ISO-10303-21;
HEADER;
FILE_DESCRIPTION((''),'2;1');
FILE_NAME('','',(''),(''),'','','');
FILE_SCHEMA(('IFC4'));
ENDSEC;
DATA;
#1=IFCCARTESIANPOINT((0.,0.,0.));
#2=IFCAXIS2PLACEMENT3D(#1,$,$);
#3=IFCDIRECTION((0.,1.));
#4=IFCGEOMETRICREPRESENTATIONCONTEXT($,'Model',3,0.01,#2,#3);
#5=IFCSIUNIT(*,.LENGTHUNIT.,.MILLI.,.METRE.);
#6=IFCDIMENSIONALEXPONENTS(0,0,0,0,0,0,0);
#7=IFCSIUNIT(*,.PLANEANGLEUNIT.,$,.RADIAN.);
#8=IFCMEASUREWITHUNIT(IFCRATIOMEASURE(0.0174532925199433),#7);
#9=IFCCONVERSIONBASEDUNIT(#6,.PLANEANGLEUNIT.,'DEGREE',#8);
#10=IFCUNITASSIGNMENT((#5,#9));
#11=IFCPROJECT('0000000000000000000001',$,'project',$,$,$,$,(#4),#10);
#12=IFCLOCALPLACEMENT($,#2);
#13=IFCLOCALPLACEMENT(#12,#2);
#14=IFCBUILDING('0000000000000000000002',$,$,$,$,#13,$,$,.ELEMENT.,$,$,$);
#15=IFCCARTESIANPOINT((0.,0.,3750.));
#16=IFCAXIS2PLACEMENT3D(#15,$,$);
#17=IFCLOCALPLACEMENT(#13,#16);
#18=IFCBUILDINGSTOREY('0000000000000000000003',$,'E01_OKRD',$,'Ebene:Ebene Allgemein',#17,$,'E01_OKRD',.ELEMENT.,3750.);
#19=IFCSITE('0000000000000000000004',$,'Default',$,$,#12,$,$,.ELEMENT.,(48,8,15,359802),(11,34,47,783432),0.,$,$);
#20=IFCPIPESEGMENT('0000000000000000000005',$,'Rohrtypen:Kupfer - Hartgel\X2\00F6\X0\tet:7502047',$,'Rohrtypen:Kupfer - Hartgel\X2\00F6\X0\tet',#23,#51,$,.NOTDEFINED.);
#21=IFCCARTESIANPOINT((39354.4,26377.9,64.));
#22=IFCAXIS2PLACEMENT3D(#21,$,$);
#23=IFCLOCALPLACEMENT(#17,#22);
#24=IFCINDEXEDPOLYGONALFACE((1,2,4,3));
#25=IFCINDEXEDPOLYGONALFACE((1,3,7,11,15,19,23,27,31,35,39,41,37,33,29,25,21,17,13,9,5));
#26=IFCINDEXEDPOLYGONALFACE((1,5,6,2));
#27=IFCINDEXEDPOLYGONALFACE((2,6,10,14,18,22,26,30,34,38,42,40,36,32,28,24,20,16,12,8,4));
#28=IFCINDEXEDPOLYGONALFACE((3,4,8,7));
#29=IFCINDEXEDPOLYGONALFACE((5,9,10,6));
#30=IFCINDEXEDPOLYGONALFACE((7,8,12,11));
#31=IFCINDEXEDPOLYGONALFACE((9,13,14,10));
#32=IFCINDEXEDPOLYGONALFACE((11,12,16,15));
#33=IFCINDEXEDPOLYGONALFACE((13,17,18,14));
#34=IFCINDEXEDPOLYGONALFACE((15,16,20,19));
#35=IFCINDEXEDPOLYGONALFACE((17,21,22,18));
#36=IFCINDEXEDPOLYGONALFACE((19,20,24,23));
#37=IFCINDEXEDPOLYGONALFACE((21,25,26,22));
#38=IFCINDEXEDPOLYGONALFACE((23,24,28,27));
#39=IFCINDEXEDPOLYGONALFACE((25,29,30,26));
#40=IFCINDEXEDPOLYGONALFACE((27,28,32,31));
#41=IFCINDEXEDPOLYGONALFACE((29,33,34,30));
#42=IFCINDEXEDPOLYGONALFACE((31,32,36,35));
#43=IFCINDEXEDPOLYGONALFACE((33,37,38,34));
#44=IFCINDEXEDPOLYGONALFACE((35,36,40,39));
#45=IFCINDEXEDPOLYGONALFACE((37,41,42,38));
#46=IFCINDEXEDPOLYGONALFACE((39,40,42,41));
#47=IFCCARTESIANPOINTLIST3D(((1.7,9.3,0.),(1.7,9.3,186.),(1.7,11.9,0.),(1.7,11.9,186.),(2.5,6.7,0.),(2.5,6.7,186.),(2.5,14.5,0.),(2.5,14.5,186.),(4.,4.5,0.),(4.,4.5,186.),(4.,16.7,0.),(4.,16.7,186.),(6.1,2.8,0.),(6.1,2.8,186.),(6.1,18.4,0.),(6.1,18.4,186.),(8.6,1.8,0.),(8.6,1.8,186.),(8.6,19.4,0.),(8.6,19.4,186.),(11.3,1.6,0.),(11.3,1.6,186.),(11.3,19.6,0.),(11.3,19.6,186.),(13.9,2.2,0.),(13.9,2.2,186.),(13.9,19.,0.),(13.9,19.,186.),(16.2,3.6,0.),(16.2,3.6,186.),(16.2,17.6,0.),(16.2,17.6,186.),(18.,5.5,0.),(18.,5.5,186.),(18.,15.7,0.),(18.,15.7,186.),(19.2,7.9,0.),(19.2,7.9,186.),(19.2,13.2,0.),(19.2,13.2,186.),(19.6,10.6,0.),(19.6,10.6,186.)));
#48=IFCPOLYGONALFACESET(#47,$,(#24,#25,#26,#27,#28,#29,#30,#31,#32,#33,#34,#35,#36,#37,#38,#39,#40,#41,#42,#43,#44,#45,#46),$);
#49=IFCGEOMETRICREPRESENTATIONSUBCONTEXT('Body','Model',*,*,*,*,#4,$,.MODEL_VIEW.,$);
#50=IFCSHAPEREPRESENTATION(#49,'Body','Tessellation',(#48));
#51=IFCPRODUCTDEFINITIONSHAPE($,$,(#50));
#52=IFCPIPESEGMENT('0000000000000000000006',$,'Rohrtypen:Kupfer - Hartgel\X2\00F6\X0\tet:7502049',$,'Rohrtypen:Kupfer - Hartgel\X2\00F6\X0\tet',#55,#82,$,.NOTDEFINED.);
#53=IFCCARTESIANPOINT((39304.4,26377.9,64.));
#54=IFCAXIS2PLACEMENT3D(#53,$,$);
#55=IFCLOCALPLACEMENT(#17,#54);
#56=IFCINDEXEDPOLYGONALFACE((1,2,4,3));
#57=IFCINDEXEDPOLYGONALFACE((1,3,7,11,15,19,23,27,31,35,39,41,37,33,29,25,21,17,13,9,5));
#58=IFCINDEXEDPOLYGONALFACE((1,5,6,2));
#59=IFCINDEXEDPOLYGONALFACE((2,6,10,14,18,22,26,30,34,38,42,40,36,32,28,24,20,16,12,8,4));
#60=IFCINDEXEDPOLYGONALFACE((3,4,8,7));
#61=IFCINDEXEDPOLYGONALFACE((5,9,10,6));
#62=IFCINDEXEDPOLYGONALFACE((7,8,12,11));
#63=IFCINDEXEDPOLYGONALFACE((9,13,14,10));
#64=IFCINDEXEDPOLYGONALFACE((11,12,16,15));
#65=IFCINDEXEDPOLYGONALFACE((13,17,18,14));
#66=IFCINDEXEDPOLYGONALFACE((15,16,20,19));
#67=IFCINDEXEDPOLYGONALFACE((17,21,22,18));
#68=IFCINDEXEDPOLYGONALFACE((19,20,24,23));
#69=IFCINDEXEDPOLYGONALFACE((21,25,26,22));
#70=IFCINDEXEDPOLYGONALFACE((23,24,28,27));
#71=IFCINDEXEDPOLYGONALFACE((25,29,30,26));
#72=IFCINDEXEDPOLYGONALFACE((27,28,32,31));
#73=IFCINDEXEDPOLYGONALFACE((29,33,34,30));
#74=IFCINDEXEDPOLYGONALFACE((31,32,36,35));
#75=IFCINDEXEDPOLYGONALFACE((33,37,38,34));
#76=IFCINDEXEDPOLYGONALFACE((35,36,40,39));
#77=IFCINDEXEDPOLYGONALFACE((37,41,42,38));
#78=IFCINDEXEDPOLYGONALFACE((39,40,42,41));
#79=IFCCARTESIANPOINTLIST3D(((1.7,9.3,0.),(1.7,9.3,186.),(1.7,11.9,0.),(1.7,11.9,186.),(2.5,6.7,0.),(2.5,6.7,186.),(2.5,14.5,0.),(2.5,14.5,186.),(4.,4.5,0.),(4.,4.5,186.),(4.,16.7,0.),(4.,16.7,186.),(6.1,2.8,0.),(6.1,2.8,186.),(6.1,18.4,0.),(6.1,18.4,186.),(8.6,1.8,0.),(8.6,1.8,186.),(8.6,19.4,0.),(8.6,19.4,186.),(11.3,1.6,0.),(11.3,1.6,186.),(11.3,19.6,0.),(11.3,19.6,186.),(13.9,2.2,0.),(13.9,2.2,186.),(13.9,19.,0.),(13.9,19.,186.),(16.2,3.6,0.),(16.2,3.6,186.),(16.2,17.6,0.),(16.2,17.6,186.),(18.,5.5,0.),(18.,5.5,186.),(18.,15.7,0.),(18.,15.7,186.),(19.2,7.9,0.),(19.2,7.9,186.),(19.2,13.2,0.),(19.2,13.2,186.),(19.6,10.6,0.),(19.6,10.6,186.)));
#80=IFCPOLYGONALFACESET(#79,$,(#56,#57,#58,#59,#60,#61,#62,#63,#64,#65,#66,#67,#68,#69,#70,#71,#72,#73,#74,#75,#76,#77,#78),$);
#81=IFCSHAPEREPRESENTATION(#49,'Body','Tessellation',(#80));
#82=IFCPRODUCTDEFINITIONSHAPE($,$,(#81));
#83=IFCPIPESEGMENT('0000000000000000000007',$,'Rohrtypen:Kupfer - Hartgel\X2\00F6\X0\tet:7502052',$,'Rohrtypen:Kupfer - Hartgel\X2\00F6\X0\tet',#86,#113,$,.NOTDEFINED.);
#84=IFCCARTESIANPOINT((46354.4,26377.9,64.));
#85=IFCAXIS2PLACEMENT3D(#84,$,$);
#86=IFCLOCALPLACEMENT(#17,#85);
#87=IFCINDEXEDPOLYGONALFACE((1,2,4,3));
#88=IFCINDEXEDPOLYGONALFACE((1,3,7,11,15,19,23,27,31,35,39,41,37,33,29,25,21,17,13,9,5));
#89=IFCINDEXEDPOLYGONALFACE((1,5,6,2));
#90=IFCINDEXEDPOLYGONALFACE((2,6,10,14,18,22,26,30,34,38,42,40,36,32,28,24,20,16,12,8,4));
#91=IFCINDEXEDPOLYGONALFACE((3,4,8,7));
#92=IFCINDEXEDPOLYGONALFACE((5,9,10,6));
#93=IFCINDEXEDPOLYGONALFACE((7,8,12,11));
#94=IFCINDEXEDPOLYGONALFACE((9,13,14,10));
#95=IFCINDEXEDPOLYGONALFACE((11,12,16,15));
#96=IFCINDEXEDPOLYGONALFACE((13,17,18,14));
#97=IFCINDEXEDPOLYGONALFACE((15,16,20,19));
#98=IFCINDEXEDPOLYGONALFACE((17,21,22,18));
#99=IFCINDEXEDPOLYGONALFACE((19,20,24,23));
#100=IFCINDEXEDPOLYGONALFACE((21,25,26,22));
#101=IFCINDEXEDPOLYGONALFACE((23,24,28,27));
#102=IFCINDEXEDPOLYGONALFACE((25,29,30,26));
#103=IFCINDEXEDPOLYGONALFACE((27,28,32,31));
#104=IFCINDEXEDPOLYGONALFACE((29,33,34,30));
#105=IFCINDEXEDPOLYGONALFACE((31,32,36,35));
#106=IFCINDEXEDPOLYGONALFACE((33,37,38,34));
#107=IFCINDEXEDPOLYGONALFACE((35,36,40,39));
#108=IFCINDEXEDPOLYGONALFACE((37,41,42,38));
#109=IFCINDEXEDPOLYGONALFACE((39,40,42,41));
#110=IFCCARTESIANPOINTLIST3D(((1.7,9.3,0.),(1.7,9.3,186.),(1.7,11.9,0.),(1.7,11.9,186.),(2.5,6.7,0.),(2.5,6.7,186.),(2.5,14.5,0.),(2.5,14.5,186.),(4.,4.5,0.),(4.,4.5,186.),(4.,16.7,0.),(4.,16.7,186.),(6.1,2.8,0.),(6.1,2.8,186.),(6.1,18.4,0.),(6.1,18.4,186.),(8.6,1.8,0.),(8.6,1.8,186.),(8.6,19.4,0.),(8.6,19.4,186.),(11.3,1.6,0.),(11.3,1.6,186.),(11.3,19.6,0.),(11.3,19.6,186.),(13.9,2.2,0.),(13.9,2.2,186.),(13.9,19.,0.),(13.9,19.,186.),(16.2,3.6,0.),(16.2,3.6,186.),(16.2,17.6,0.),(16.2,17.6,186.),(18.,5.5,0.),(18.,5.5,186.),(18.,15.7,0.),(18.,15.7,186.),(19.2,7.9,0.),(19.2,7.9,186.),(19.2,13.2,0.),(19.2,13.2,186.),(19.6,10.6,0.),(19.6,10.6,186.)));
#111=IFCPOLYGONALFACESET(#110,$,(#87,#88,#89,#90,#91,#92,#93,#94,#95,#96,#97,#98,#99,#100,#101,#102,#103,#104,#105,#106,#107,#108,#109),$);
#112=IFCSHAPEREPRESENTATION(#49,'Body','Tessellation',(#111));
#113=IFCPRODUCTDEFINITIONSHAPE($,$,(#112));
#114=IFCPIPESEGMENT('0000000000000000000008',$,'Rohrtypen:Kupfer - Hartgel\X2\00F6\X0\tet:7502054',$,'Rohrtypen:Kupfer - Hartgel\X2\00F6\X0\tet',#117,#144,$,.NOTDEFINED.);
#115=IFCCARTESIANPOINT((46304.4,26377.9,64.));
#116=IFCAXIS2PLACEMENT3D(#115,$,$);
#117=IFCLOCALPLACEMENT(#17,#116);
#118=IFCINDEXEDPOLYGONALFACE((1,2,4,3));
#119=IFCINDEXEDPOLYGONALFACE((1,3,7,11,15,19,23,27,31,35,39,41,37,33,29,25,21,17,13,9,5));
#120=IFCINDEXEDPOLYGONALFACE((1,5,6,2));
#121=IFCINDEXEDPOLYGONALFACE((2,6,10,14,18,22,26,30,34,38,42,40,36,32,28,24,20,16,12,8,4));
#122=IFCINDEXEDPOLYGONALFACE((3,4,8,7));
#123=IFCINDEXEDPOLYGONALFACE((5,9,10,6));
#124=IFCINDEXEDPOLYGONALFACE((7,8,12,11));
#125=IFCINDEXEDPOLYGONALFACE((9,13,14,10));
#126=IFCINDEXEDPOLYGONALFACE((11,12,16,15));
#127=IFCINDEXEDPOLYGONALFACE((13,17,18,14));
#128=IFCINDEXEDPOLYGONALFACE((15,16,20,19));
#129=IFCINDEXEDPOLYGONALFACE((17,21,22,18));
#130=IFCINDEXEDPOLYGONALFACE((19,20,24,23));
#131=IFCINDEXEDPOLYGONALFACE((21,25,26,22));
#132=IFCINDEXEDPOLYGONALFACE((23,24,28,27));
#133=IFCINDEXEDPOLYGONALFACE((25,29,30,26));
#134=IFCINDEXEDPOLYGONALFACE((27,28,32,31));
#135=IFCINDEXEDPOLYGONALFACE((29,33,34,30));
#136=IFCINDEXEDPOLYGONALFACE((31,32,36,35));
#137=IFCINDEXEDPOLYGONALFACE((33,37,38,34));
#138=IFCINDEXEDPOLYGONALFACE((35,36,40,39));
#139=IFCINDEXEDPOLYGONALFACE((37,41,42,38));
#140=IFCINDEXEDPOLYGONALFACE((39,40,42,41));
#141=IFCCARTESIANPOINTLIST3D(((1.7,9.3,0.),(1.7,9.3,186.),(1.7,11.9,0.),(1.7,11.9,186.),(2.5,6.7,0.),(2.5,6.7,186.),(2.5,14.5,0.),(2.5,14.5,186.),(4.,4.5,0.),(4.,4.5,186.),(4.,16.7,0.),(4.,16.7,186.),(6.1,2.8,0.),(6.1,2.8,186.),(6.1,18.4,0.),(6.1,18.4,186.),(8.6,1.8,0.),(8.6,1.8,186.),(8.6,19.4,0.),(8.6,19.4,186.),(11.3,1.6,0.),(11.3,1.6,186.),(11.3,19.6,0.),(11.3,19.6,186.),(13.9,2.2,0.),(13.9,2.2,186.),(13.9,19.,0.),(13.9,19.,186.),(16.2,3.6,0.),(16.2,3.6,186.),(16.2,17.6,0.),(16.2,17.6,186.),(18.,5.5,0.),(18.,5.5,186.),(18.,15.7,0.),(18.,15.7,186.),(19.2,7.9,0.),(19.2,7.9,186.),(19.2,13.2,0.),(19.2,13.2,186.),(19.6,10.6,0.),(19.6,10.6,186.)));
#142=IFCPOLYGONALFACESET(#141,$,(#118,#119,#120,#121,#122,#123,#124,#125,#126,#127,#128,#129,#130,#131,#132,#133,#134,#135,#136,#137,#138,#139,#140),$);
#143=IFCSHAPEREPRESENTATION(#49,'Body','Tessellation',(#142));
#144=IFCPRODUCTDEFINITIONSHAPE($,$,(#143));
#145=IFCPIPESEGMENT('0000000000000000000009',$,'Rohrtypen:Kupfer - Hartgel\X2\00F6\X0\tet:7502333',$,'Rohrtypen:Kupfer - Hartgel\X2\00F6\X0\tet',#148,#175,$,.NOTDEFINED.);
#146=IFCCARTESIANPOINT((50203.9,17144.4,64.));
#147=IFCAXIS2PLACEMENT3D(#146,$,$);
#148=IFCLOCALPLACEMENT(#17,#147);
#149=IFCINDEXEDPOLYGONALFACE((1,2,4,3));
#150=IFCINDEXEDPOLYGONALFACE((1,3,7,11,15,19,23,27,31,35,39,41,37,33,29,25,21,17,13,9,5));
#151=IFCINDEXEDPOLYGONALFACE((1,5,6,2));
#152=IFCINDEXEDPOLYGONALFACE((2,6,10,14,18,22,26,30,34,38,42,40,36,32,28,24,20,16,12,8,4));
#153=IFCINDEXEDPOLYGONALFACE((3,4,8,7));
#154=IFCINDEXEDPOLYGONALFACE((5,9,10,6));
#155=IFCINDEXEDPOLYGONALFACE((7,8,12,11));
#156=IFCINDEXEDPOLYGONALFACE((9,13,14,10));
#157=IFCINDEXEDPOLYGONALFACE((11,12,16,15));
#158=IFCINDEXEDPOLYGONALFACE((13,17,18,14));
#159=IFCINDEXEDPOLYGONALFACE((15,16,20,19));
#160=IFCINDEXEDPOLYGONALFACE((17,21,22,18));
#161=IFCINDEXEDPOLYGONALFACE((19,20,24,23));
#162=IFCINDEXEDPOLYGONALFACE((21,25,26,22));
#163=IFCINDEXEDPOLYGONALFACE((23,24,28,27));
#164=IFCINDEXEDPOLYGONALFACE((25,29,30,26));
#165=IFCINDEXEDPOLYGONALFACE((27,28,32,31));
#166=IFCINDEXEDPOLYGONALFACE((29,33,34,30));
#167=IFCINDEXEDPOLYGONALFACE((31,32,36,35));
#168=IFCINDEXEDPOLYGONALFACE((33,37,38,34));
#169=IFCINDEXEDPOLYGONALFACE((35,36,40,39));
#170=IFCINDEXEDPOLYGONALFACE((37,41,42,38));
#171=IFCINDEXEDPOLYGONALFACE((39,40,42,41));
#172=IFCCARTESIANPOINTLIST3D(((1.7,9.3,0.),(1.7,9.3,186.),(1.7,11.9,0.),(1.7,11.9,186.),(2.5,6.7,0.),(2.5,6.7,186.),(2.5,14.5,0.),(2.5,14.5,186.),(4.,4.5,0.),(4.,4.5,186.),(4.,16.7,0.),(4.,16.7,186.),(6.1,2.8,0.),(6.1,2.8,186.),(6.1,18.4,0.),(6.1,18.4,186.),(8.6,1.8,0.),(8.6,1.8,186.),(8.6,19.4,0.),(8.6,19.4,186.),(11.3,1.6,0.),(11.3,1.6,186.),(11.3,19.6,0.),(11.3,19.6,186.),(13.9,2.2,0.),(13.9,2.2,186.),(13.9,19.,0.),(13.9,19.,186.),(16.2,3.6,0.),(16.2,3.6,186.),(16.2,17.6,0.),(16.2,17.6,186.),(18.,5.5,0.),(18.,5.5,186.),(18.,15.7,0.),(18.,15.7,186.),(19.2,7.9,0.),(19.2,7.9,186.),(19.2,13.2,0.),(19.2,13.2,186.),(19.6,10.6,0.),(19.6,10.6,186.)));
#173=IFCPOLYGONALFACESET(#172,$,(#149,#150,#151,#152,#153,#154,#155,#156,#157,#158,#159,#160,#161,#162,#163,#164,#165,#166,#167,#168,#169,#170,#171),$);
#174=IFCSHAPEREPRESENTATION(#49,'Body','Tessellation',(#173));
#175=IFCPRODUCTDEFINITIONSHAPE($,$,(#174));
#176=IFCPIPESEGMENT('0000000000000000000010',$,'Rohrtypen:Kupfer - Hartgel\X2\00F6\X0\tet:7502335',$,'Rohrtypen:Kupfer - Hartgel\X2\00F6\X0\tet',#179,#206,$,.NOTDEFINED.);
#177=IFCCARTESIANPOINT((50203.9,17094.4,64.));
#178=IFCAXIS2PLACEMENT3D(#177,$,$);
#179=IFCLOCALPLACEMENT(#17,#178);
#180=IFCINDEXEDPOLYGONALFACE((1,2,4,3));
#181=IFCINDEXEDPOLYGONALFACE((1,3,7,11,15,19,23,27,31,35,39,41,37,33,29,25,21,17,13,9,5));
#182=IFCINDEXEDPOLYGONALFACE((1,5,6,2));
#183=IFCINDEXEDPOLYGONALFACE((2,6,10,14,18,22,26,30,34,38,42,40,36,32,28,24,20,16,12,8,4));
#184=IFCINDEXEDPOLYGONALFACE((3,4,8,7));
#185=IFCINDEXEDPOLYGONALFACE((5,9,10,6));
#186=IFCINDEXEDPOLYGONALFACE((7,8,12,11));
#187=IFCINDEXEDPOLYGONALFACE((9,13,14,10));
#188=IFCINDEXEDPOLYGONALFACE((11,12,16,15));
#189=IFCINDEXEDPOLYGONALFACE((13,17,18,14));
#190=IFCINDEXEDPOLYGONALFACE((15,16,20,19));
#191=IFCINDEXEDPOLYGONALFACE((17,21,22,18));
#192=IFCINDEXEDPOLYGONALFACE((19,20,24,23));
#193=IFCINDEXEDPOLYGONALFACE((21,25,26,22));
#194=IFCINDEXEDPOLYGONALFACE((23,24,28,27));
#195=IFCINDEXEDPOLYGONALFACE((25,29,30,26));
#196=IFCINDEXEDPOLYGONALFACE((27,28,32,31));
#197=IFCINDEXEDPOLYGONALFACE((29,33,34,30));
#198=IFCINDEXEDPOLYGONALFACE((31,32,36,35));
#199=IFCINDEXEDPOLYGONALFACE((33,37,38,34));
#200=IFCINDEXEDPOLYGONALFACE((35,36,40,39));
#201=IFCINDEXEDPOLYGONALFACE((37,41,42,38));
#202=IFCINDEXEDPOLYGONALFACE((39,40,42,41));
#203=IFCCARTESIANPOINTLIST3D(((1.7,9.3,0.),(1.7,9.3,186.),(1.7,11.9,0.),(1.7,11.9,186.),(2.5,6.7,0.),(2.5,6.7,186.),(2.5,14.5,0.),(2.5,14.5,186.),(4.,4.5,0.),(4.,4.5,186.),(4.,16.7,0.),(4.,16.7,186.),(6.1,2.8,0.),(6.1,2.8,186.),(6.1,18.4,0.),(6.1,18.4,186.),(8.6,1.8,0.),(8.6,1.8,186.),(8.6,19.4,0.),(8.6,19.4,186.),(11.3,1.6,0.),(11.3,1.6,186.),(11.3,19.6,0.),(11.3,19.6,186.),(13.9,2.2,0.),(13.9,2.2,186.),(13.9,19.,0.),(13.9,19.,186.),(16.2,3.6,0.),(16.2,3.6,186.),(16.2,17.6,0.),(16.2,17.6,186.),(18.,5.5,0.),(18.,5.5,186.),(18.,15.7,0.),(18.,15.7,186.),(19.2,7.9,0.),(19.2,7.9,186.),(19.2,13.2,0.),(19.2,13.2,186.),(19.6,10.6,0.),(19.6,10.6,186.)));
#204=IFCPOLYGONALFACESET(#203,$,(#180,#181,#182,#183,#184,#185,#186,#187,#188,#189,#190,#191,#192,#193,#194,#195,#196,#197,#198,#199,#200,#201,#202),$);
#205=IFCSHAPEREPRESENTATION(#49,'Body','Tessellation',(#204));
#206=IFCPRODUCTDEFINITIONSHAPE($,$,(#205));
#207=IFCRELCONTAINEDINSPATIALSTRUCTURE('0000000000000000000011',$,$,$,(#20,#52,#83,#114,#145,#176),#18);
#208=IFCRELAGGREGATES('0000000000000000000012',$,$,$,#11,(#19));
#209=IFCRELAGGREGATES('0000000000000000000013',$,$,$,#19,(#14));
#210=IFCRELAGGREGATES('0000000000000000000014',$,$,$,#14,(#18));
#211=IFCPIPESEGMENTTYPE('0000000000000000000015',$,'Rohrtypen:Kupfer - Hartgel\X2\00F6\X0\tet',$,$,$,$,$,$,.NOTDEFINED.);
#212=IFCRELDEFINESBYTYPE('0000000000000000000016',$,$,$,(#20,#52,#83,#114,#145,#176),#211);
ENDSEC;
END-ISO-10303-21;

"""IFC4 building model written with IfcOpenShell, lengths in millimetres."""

from ifc_helpers import new_model, entity, si_unit, converted_unit, direction, frame, origin, origin_2d_with_axis, place, context, subcontext, project, spatial, circle, extrude, type_object, element, save


model = new_model("IFC4")

# Units and contexts
model_context = context("Model", 3, precision=0.01, world=origin(), true_north=direction((0.0, 1.0)))
body_context = subcontext(model_context, "Body", "Model", "MODEL_VIEW")
ifc_project = project(units=[si_unit("LENGTHUNIT", "METRE", prefix="MILLI"), converted_unit("PLANEANGLEUNIT", "DEGREE", entity("IfcRatioMeasure", 0.0174532925199433), si_unit("PLANEANGLEUNIT", "RADIAN"), dimensions=[0, 0, 0, 0, 0, 0, 0])], contexts=[model_context])

# Site, building, storey
site_placement = place(None, origin())
site = spatial("IfcSite", under=ifc_project, at=site_placement, Name="Default", CompositionType="ELEMENT", RefLatitude=(48, 8, 15, 359802), RefLongitude=(11, 34, 47, 783432), RefElevation=0.0)
building_placement = place(site_placement, origin())
building = spatial("IfcBuilding", under=site, at=building_placement, CompositionType="ELEMENT")
storey_placement = place(building_placement, frame((0.0, 0.0, 3750.0)))
storey = spatial("IfcBuildingStorey", under=building, at=storey_placement, Name="E01_OKRD", ObjectType="Ebene:Ebene Allgemein", LongName="E01_OKRD", CompositionType="ELEMENT", Elevation=3750.0)

# Pipe segments
pipe_segment_type = type_object("IfcPipeSegmentType", Name="Rohrtypen:Kupfer - Hartgelötet", PredefinedType="NOTDEFINED")
pipe_segment_1_placement = place(storey_placement, frame((39354.4, 26377.9, 64.0)))
element("IfcPipeSegment", 1, at=pipe_segment_1_placement, inside=storey, type_object=pipe_segment_type, Name="Rohrtypen:Kupfer - Hartgelötet:7502047", ObjectType="Rohrtypen:Kupfer - Hartgelötet", PredefinedType="NOTDEFINED", context=body_context, shape_type="SweptSolid", body=[
    extrude(circle(Radius=9.0, at=origin_2d_with_axis()), frame((10.6, 10.6, 0.0)), (0.0, 0.0, 1.0), 186.0),
])
pipe_segment_2_placement = place(storey_placement, frame((39304.4, 26377.9, 64.0)))
element("IfcPipeSegment", 2, at=pipe_segment_2_placement, inside=storey, type_object=pipe_segment_type, Name="Rohrtypen:Kupfer - Hartgelötet:7502049", ObjectType="Rohrtypen:Kupfer - Hartgelötet", PredefinedType="NOTDEFINED", context=body_context, shape_type="SweptSolid", body=[
    extrude(circle(Radius=9.0, at=origin_2d_with_axis()), frame((10.6, 10.6, 0.0)), (0.0, 0.0, 1.0), 186.0),
])
pipe_segment_3_placement = place(storey_placement, frame((46354.4, 26377.9, 64.0)))
element("IfcPipeSegment", 3, at=pipe_segment_3_placement, inside=storey, type_object=pipe_segment_type, Name="Rohrtypen:Kupfer - Hartgelötet:7502052", ObjectType="Rohrtypen:Kupfer - Hartgelötet", PredefinedType="NOTDEFINED", context=body_context, shape_type="SweptSolid", body=[
    extrude(circle(Radius=9.0, at=origin_2d_with_axis()), frame((10.6, 10.6, 0.0)), (0.0, 0.0, 1.0), 186.0),
])
pipe_segment_4_placement = place(storey_placement, frame((46304.4, 26377.9, 64.0)))
element("IfcPipeSegment", 4, at=pipe_segment_4_placement, inside=storey, type_object=pipe_segment_type, Name="Rohrtypen:Kupfer - Hartgelötet:7502054", ObjectType="Rohrtypen:Kupfer - Hartgelötet", PredefinedType="NOTDEFINED", context=body_context, shape_type="SweptSolid", body=[
    extrude(circle(Radius=9.0, at=origin_2d_with_axis()), frame((10.6, 10.6, 0.0)), (0.0, 0.0, 1.0), 186.0),
])
pipe_segment_5_placement = place(storey_placement, frame((50203.9, 17144.4, 64.0)))
element("IfcPipeSegment", 5, at=pipe_segment_5_placement, inside=storey, type_object=pipe_segment_type, Name="Rohrtypen:Kupfer - Hartgelötet:7502333", ObjectType="Rohrtypen:Kupfer - Hartgelötet", PredefinedType="NOTDEFINED", context=body_context, shape_type="SweptSolid", body=[
    extrude(circle(Radius=9.0, at=origin_2d_with_axis()), frame((10.6, 10.6, 0.0)), (0.0, 0.0, 1.0), 186.0),
])
pipe_segment_6_placement = place(storey_placement, frame((50203.9, 17094.4, 64.0)))
element("IfcPipeSegment", 6, at=pipe_segment_6_placement, inside=storey, type_object=pipe_segment_type, Name="Rohrtypen:Kupfer - Hartgelötet:7502335", ObjectType="Rohrtypen:Kupfer - Hartgelötet", PredefinedType="NOTDEFINED", context=body_context, shape_type="SweptSolid", body=[
    extrude(circle(Radius=9.0, at=origin_2d_with_axis()), frame((10.6, 10.6, 0.0)), (0.0, 0.0, 1.0), 186.0),
])

save(model, "model.ifc")
